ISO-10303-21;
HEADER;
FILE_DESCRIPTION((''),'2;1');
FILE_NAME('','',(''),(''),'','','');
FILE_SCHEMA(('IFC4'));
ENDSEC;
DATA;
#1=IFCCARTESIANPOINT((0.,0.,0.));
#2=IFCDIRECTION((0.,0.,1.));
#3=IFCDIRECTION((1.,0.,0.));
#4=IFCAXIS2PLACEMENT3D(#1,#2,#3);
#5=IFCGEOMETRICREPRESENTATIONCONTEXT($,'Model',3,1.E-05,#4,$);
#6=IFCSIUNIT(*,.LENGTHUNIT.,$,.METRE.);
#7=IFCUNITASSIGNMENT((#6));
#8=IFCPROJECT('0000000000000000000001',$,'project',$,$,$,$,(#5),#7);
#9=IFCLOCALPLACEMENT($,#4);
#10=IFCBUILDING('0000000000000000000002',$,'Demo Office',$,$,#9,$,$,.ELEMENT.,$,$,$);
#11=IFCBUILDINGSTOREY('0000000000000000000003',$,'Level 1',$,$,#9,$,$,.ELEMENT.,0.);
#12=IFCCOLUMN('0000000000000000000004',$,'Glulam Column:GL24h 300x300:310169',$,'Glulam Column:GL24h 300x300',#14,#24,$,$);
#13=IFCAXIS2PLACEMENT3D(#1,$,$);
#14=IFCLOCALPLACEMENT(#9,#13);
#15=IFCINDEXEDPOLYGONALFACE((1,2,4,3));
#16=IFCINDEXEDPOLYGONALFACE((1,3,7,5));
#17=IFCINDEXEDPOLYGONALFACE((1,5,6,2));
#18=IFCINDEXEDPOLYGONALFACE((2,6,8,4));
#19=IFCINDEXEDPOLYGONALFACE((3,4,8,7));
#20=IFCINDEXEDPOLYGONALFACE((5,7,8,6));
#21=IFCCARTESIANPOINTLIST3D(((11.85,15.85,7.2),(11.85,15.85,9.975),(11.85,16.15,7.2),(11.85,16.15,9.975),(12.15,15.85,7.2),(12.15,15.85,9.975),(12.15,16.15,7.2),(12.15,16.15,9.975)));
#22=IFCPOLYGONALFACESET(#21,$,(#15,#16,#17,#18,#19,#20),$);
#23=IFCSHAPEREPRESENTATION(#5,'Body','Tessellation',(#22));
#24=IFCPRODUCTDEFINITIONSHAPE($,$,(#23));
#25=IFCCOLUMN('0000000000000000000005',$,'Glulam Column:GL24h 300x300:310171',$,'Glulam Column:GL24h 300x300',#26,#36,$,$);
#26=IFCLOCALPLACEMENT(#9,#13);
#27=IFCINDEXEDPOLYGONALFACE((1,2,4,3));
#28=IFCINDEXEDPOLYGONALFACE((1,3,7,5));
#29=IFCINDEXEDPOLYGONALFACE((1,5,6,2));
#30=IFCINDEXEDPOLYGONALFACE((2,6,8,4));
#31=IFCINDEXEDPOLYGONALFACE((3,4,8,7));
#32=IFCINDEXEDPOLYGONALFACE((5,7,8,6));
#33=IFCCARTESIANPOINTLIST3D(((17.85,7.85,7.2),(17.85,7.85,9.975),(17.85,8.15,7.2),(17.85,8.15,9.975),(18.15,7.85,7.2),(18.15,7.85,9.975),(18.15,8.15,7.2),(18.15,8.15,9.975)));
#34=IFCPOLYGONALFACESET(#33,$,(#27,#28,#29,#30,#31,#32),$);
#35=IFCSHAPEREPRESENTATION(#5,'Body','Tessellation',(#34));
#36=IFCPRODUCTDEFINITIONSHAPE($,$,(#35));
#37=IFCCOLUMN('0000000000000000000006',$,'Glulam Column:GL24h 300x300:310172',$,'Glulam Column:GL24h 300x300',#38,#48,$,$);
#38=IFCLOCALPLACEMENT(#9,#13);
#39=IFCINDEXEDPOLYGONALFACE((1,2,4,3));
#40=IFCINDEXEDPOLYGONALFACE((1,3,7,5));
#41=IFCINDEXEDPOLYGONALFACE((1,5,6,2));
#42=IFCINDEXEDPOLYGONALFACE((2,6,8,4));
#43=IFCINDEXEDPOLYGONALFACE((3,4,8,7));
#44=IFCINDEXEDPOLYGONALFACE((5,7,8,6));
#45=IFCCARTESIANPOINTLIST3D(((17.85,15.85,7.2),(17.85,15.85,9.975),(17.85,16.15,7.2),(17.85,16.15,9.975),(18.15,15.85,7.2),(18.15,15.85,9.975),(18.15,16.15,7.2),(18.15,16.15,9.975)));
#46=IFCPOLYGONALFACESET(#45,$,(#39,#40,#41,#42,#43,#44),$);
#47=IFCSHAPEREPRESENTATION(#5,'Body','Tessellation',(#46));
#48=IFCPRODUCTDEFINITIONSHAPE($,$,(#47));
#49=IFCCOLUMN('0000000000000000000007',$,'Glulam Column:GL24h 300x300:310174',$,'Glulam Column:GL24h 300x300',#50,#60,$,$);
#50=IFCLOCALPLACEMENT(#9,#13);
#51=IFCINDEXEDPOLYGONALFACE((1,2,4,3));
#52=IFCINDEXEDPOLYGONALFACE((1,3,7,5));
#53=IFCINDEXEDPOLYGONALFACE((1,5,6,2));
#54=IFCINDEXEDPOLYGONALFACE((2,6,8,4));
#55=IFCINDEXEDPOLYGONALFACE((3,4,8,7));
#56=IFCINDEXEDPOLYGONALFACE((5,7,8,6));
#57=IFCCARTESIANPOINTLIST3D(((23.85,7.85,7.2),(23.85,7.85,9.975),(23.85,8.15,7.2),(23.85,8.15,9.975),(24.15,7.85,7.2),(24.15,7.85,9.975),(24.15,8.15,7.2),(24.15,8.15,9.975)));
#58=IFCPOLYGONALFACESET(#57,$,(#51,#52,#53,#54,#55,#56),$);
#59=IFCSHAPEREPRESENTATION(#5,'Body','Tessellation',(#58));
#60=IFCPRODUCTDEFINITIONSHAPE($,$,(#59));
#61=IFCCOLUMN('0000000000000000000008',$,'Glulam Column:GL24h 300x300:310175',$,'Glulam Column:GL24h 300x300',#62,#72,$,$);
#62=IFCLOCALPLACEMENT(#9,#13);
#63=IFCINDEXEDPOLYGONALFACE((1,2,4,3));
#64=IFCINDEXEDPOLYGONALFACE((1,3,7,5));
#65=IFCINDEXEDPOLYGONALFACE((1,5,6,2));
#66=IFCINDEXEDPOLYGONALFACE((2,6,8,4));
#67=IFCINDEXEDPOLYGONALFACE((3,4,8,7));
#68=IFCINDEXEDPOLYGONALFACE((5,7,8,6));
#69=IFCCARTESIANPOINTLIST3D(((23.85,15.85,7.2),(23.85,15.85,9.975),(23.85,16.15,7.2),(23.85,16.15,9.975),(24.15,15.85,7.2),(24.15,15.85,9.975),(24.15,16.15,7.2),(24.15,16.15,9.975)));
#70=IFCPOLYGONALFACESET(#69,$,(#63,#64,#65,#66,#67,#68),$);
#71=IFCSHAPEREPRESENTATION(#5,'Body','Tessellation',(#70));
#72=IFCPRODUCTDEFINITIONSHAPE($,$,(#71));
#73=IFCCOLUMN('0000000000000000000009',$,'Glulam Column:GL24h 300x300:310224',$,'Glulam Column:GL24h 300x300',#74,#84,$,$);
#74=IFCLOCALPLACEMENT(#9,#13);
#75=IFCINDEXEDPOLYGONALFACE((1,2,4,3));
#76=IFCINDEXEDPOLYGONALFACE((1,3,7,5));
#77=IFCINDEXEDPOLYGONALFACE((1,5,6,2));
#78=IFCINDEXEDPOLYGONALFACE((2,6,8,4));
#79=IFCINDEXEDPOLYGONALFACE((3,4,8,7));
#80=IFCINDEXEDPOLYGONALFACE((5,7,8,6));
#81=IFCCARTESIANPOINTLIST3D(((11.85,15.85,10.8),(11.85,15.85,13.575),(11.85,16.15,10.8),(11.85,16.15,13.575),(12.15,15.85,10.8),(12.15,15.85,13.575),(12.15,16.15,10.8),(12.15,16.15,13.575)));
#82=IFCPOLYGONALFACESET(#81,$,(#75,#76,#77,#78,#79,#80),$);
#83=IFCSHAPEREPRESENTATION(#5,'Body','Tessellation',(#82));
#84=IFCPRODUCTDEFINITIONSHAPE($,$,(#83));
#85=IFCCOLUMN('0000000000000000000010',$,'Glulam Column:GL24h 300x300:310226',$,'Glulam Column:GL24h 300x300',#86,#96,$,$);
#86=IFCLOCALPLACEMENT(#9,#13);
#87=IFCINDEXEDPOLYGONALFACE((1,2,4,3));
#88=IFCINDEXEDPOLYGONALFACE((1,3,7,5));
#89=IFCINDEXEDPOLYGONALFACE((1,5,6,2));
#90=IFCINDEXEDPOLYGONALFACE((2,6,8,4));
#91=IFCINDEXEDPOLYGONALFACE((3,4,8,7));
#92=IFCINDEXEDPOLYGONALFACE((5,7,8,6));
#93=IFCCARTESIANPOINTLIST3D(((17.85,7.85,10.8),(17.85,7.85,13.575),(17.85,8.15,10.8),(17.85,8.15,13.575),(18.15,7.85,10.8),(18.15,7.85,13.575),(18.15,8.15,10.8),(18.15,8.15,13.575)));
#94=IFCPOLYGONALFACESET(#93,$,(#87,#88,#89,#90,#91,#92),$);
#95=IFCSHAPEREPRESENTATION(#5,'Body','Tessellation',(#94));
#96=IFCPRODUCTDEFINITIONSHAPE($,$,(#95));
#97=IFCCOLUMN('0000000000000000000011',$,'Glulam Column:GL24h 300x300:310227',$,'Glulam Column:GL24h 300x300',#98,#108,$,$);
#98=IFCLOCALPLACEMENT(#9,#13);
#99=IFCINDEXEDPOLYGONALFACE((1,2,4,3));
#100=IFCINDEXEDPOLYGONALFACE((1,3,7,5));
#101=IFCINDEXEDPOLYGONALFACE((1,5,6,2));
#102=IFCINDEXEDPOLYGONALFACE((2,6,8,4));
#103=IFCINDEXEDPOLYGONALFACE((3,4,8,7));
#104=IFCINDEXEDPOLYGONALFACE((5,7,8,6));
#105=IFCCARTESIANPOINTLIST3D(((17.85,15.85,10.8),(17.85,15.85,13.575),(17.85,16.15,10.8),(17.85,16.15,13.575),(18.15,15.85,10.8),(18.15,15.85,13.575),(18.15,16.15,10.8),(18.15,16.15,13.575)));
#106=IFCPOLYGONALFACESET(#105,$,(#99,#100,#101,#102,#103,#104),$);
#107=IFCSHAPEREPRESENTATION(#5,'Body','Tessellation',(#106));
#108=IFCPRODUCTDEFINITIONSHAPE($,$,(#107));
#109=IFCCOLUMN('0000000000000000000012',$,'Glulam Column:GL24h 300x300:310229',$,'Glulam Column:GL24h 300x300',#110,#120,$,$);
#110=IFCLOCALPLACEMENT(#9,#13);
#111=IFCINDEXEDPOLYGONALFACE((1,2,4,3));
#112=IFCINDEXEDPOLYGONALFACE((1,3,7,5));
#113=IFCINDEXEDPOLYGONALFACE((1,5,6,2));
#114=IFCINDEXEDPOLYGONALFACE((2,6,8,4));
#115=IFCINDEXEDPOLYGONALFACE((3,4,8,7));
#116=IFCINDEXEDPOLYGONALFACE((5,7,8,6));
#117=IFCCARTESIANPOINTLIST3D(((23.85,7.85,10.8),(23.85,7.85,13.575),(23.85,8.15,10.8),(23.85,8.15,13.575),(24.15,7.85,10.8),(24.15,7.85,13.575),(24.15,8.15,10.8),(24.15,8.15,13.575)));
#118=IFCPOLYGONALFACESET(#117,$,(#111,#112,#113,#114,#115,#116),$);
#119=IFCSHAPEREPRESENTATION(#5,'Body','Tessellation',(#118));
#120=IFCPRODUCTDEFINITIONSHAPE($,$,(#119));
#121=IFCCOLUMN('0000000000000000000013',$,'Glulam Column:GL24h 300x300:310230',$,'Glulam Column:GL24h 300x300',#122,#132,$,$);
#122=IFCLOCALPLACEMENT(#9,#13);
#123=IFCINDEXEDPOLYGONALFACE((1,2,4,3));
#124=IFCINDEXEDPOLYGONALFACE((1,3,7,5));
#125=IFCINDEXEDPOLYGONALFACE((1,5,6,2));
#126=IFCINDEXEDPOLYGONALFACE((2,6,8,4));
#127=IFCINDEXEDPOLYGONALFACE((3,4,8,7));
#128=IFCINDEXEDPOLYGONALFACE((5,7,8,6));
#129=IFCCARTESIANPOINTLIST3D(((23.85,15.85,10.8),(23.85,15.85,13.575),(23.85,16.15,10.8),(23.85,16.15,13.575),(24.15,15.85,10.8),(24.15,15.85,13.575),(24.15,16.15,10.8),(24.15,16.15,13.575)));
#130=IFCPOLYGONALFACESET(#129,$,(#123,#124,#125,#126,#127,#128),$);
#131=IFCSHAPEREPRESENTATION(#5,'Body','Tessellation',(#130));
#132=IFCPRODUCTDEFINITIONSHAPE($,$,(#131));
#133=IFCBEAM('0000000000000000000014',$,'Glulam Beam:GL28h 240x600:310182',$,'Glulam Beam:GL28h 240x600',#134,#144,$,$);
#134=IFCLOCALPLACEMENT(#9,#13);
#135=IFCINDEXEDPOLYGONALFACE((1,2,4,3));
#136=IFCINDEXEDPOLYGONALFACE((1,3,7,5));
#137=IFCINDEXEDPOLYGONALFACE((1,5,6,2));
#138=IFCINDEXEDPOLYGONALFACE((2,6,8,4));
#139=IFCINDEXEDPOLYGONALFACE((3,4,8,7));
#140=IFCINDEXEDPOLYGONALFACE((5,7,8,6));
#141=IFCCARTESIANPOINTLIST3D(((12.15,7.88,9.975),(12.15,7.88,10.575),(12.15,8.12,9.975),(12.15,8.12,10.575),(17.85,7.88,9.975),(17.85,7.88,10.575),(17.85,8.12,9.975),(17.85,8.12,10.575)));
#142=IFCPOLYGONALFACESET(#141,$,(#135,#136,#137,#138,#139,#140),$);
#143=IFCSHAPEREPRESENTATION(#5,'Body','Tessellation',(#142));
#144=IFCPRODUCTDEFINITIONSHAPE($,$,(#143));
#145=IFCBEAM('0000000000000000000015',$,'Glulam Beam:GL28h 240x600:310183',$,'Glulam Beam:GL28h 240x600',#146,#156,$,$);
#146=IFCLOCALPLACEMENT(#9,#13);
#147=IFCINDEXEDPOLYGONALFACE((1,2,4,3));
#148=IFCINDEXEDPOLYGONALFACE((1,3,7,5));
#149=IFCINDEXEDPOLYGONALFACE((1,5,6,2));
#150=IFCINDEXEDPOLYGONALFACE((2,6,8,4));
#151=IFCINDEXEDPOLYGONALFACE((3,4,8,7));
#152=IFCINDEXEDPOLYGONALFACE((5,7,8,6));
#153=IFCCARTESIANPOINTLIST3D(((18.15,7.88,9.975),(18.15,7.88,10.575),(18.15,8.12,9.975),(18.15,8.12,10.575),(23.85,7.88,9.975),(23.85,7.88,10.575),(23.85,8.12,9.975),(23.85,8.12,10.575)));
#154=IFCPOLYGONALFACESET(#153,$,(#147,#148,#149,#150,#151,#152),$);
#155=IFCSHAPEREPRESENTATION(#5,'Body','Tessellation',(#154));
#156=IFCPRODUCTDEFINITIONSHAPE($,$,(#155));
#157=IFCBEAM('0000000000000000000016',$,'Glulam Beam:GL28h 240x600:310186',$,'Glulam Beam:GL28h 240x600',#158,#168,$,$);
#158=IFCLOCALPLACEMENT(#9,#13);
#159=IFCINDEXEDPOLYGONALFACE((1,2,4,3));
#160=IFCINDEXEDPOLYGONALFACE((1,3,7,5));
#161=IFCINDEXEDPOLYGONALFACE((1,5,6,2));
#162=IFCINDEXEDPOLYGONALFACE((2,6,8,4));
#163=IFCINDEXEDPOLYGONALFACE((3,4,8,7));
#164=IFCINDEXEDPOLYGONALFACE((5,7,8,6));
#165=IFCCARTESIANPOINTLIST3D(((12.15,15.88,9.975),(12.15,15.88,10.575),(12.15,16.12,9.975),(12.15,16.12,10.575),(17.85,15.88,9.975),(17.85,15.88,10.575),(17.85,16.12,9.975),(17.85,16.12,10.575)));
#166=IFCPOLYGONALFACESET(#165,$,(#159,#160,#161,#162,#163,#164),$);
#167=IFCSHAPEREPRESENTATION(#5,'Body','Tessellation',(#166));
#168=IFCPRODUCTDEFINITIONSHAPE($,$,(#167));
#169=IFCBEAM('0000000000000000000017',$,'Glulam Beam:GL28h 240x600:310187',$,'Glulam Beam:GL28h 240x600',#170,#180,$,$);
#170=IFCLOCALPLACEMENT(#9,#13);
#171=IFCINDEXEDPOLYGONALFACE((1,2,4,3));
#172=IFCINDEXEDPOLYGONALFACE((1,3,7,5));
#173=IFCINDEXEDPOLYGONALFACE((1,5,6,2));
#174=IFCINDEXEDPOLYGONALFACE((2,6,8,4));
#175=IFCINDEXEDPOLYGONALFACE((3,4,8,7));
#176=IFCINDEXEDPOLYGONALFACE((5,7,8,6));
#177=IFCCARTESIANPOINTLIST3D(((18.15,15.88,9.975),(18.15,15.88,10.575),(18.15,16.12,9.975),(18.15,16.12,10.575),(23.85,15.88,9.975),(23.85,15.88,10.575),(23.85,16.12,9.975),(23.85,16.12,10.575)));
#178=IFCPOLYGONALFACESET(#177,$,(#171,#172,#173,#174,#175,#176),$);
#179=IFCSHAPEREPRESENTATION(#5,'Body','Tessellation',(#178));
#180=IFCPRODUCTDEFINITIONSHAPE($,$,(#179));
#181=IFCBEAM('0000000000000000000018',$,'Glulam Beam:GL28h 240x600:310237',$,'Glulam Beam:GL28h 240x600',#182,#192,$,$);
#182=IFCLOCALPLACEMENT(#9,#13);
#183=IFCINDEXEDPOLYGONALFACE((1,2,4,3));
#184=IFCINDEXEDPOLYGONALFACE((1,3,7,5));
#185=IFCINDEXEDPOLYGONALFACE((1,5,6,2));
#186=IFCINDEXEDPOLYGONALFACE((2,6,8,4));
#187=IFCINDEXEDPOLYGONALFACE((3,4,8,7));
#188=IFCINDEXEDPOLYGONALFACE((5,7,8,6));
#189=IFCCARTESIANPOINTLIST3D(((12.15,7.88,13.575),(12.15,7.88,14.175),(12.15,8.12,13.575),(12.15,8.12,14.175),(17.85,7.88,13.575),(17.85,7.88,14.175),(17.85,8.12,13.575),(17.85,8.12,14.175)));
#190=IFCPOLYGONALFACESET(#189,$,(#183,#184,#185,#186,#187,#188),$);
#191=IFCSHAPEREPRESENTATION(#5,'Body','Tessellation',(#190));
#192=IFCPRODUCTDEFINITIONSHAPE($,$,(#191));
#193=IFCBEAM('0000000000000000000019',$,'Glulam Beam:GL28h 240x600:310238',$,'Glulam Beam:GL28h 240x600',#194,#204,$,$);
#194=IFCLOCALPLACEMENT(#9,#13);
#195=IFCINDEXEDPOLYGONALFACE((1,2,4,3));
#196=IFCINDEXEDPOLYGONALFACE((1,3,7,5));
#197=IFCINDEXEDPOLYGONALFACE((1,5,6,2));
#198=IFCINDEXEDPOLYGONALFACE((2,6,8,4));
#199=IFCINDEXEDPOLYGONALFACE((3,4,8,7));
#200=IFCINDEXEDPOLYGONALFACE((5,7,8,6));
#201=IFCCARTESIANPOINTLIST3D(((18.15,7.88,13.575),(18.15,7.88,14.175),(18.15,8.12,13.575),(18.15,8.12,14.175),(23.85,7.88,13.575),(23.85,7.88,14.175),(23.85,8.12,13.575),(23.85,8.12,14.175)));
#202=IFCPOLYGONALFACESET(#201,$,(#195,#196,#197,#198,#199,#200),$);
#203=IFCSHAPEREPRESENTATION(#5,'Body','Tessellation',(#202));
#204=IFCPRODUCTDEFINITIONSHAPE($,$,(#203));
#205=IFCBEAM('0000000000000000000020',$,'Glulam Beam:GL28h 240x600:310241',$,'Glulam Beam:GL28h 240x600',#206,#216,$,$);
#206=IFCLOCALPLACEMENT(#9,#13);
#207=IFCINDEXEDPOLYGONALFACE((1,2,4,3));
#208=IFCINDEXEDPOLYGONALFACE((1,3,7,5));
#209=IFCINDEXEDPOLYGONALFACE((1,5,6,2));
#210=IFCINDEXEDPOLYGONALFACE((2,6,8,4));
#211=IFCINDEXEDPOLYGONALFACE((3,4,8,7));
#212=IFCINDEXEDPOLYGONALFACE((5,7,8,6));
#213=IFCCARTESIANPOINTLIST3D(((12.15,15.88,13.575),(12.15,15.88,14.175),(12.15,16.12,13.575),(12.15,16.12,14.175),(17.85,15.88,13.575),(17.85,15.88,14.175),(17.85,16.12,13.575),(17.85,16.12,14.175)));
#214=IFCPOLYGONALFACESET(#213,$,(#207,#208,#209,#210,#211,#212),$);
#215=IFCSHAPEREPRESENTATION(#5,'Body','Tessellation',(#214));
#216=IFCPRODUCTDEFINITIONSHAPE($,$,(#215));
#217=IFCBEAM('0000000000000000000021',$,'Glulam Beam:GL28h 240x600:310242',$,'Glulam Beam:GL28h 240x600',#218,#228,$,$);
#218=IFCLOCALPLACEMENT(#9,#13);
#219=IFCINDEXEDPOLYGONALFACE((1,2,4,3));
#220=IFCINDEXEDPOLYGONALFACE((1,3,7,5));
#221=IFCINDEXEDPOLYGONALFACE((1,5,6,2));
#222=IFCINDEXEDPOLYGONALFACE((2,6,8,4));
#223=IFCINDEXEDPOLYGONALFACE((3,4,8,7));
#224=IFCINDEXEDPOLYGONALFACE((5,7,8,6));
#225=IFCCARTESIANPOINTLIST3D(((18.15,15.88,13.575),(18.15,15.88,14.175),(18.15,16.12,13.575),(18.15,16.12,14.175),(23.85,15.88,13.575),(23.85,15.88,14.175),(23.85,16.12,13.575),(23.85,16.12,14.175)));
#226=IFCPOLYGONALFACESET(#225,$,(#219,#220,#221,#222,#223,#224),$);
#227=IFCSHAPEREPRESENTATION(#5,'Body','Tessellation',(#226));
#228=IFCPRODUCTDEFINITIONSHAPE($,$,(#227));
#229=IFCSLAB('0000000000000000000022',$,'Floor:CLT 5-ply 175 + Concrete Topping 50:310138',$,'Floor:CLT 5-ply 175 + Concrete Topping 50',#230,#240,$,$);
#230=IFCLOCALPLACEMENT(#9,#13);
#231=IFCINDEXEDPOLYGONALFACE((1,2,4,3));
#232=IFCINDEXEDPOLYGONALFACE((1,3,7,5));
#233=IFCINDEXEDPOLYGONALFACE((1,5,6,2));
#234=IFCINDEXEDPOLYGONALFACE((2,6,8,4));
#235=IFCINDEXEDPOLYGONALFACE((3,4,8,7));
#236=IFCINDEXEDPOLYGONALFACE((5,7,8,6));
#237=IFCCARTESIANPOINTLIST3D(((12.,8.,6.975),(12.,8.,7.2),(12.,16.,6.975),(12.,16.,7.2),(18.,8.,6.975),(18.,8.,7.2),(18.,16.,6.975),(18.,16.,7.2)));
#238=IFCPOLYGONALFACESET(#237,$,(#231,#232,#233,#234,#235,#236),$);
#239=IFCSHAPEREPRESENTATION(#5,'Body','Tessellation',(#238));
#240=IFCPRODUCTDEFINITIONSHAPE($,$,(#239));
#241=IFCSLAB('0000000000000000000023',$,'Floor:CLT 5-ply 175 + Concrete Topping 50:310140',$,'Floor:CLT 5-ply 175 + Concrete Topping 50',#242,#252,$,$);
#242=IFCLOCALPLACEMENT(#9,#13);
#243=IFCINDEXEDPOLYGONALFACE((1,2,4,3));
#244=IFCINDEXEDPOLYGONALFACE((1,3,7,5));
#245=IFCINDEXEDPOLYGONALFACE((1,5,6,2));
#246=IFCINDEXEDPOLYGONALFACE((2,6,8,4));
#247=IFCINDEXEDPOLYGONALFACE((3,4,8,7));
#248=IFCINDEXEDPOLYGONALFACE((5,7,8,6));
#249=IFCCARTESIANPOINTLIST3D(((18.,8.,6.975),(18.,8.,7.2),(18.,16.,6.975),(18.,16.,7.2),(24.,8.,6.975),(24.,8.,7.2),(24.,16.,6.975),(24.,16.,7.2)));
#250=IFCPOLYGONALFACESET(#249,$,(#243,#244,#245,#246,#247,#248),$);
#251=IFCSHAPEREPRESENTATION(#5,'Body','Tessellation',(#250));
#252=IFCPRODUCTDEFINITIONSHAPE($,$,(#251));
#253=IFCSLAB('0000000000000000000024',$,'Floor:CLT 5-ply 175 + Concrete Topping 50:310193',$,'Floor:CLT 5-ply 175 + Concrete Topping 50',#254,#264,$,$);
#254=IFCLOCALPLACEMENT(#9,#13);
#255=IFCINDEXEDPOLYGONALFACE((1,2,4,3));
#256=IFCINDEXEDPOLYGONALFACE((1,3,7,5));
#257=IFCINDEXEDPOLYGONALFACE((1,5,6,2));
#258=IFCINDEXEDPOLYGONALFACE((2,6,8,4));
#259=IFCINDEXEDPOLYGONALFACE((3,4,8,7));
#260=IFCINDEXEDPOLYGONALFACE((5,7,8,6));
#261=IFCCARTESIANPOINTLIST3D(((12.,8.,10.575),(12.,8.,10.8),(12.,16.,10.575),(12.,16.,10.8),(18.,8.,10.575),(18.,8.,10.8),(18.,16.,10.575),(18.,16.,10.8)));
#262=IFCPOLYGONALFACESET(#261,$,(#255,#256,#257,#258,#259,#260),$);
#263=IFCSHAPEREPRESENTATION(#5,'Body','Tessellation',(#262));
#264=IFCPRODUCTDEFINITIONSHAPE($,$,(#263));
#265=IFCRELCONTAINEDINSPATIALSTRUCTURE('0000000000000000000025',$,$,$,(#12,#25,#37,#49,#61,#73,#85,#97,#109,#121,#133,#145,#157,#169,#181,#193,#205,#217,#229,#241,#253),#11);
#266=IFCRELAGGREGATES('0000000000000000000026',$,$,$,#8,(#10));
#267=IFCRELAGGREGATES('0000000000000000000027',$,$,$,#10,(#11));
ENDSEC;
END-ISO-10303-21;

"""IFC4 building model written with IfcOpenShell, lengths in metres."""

from ifc_helpers import new_model, si_unit, frame, origin_with_axes, origin_2d, place, context, project, spatial, rectangle, extrude, element, save


model = new_model("IFC4")

# Units and contexts
model_context = context("Model", 3, precision=1e-05, world=origin_with_axes())
ifc_project = project(units=[si_unit("LENGTHUNIT", "METRE")], contexts=[model_context])

# Building, storey
placement = place(None, origin_with_axes())
building = spatial("IfcBuilding", under=ifc_project, at=placement, Name="Demo Office", CompositionType="ELEMENT")
storey = spatial("IfcBuildingStorey", under=building, at=placement, Name="Level 1", CompositionType="ELEMENT", Elevation=0.0)

# Columns
for number, where, name in (
    (1, (12.0, 16.0, 7.2), "Glulam Column:GL24h 300x300:310169"),
    (2, (18.0, 8.0, 7.2), "Glulam Column:GL24h 300x300:310171"),
    (3, (18.0, 16.0, 7.2), "Glulam Column:GL24h 300x300:310172"),
    (4, (24.0, 8.0, 7.2), "Glulam Column:GL24h 300x300:310174"),
    (5, (24.0, 16.0, 7.2), "Glulam Column:GL24h 300x300:310175"),
    (6, (12.0, 16.0, 10.8), "Glulam Column:GL24h 300x300:310224"),
    (7, (18.0, 8.0, 10.8), "Glulam Column:GL24h 300x300:310226"),
    (8, (18.0, 16.0, 10.8), "Glulam Column:GL24h 300x300:310227"),
    (9, (24.0, 8.0, 10.8), "Glulam Column:GL24h 300x300:310229"),
    (10, (24.0, 16.0, 10.8), "Glulam Column:GL24h 300x300:310230"),
):
    element("IfcColumn", number, at=place(placement, frame(where)), inside=storey, Name=name, ObjectType="Glulam Column:GL24h 300x300", context=model_context, shape_type="SweptSolid", body=[
        extrude(rectangle(XDim=0.3, YDim=0.3, at=origin_2d()), origin_with_axes(), (0.0, 0.0, 1.0), 2.775),
    ])

# Beams
for number, where, name in (
    (11, (15.0, 8.0, 9.975), "Glulam Beam:GL28h 240x600:310182"),
    (12, (21.0, 8.0, 9.975), "Glulam Beam:GL28h 240x600:310183"),
    (13, (15.0, 16.0, 9.975), "Glulam Beam:GL28h 240x600:310186"),
    (14, (21.0, 16.0, 9.975), "Glulam Beam:GL28h 240x600:310187"),
    (15, (15.0, 8.0, 13.575), "Glulam Beam:GL28h 240x600:310237"),
    (16, (21.0, 8.0, 13.575), "Glulam Beam:GL28h 240x600:310238"),
    (17, (15.0, 16.0, 13.575), "Glulam Beam:GL28h 240x600:310241"),
    (18, (21.0, 16.0, 13.575), "Glulam Beam:GL28h 240x600:310242"),
):
    element("IfcBeam", number, at=place(placement, frame(where)), inside=storey, Name=name, ObjectType="Glulam Beam:GL28h 240x600", context=model_context, shape_type="SweptSolid", body=[
        extrude(rectangle(XDim=5.7, YDim=0.24, at=origin_2d()), origin_with_axes(), (0.0, 0.0, 1.0), 0.6),
    ])

# Slabs
for number, where, name in (
    (19, (15.0, 12.0, 6.975), "Floor:CLT 5-ply 175 + Concrete Topping 50:310138"),
    (20, (21.0, 12.0, 6.975), "Floor:CLT 5-ply 175 + Concrete Topping 50:310140"),
    (21, (15.0, 12.0, 10.575), "Floor:CLT 5-ply 175 + Concrete Topping 50:310193"),
):
    element("IfcSlab", number, at=place(placement, frame(where)), inside=storey, Name=name, ObjectType="Floor:CLT 5-ply 175 + Concrete Topping 50", context=model_context, shape_type="SweptSolid", body=[
        extrude(rectangle(XDim=6.0, YDim=8.0, at=origin_2d()), origin_with_axes(), (0.0, 0.0, 1.0), 0.225),
    ])

save(model, "model.ifc")
